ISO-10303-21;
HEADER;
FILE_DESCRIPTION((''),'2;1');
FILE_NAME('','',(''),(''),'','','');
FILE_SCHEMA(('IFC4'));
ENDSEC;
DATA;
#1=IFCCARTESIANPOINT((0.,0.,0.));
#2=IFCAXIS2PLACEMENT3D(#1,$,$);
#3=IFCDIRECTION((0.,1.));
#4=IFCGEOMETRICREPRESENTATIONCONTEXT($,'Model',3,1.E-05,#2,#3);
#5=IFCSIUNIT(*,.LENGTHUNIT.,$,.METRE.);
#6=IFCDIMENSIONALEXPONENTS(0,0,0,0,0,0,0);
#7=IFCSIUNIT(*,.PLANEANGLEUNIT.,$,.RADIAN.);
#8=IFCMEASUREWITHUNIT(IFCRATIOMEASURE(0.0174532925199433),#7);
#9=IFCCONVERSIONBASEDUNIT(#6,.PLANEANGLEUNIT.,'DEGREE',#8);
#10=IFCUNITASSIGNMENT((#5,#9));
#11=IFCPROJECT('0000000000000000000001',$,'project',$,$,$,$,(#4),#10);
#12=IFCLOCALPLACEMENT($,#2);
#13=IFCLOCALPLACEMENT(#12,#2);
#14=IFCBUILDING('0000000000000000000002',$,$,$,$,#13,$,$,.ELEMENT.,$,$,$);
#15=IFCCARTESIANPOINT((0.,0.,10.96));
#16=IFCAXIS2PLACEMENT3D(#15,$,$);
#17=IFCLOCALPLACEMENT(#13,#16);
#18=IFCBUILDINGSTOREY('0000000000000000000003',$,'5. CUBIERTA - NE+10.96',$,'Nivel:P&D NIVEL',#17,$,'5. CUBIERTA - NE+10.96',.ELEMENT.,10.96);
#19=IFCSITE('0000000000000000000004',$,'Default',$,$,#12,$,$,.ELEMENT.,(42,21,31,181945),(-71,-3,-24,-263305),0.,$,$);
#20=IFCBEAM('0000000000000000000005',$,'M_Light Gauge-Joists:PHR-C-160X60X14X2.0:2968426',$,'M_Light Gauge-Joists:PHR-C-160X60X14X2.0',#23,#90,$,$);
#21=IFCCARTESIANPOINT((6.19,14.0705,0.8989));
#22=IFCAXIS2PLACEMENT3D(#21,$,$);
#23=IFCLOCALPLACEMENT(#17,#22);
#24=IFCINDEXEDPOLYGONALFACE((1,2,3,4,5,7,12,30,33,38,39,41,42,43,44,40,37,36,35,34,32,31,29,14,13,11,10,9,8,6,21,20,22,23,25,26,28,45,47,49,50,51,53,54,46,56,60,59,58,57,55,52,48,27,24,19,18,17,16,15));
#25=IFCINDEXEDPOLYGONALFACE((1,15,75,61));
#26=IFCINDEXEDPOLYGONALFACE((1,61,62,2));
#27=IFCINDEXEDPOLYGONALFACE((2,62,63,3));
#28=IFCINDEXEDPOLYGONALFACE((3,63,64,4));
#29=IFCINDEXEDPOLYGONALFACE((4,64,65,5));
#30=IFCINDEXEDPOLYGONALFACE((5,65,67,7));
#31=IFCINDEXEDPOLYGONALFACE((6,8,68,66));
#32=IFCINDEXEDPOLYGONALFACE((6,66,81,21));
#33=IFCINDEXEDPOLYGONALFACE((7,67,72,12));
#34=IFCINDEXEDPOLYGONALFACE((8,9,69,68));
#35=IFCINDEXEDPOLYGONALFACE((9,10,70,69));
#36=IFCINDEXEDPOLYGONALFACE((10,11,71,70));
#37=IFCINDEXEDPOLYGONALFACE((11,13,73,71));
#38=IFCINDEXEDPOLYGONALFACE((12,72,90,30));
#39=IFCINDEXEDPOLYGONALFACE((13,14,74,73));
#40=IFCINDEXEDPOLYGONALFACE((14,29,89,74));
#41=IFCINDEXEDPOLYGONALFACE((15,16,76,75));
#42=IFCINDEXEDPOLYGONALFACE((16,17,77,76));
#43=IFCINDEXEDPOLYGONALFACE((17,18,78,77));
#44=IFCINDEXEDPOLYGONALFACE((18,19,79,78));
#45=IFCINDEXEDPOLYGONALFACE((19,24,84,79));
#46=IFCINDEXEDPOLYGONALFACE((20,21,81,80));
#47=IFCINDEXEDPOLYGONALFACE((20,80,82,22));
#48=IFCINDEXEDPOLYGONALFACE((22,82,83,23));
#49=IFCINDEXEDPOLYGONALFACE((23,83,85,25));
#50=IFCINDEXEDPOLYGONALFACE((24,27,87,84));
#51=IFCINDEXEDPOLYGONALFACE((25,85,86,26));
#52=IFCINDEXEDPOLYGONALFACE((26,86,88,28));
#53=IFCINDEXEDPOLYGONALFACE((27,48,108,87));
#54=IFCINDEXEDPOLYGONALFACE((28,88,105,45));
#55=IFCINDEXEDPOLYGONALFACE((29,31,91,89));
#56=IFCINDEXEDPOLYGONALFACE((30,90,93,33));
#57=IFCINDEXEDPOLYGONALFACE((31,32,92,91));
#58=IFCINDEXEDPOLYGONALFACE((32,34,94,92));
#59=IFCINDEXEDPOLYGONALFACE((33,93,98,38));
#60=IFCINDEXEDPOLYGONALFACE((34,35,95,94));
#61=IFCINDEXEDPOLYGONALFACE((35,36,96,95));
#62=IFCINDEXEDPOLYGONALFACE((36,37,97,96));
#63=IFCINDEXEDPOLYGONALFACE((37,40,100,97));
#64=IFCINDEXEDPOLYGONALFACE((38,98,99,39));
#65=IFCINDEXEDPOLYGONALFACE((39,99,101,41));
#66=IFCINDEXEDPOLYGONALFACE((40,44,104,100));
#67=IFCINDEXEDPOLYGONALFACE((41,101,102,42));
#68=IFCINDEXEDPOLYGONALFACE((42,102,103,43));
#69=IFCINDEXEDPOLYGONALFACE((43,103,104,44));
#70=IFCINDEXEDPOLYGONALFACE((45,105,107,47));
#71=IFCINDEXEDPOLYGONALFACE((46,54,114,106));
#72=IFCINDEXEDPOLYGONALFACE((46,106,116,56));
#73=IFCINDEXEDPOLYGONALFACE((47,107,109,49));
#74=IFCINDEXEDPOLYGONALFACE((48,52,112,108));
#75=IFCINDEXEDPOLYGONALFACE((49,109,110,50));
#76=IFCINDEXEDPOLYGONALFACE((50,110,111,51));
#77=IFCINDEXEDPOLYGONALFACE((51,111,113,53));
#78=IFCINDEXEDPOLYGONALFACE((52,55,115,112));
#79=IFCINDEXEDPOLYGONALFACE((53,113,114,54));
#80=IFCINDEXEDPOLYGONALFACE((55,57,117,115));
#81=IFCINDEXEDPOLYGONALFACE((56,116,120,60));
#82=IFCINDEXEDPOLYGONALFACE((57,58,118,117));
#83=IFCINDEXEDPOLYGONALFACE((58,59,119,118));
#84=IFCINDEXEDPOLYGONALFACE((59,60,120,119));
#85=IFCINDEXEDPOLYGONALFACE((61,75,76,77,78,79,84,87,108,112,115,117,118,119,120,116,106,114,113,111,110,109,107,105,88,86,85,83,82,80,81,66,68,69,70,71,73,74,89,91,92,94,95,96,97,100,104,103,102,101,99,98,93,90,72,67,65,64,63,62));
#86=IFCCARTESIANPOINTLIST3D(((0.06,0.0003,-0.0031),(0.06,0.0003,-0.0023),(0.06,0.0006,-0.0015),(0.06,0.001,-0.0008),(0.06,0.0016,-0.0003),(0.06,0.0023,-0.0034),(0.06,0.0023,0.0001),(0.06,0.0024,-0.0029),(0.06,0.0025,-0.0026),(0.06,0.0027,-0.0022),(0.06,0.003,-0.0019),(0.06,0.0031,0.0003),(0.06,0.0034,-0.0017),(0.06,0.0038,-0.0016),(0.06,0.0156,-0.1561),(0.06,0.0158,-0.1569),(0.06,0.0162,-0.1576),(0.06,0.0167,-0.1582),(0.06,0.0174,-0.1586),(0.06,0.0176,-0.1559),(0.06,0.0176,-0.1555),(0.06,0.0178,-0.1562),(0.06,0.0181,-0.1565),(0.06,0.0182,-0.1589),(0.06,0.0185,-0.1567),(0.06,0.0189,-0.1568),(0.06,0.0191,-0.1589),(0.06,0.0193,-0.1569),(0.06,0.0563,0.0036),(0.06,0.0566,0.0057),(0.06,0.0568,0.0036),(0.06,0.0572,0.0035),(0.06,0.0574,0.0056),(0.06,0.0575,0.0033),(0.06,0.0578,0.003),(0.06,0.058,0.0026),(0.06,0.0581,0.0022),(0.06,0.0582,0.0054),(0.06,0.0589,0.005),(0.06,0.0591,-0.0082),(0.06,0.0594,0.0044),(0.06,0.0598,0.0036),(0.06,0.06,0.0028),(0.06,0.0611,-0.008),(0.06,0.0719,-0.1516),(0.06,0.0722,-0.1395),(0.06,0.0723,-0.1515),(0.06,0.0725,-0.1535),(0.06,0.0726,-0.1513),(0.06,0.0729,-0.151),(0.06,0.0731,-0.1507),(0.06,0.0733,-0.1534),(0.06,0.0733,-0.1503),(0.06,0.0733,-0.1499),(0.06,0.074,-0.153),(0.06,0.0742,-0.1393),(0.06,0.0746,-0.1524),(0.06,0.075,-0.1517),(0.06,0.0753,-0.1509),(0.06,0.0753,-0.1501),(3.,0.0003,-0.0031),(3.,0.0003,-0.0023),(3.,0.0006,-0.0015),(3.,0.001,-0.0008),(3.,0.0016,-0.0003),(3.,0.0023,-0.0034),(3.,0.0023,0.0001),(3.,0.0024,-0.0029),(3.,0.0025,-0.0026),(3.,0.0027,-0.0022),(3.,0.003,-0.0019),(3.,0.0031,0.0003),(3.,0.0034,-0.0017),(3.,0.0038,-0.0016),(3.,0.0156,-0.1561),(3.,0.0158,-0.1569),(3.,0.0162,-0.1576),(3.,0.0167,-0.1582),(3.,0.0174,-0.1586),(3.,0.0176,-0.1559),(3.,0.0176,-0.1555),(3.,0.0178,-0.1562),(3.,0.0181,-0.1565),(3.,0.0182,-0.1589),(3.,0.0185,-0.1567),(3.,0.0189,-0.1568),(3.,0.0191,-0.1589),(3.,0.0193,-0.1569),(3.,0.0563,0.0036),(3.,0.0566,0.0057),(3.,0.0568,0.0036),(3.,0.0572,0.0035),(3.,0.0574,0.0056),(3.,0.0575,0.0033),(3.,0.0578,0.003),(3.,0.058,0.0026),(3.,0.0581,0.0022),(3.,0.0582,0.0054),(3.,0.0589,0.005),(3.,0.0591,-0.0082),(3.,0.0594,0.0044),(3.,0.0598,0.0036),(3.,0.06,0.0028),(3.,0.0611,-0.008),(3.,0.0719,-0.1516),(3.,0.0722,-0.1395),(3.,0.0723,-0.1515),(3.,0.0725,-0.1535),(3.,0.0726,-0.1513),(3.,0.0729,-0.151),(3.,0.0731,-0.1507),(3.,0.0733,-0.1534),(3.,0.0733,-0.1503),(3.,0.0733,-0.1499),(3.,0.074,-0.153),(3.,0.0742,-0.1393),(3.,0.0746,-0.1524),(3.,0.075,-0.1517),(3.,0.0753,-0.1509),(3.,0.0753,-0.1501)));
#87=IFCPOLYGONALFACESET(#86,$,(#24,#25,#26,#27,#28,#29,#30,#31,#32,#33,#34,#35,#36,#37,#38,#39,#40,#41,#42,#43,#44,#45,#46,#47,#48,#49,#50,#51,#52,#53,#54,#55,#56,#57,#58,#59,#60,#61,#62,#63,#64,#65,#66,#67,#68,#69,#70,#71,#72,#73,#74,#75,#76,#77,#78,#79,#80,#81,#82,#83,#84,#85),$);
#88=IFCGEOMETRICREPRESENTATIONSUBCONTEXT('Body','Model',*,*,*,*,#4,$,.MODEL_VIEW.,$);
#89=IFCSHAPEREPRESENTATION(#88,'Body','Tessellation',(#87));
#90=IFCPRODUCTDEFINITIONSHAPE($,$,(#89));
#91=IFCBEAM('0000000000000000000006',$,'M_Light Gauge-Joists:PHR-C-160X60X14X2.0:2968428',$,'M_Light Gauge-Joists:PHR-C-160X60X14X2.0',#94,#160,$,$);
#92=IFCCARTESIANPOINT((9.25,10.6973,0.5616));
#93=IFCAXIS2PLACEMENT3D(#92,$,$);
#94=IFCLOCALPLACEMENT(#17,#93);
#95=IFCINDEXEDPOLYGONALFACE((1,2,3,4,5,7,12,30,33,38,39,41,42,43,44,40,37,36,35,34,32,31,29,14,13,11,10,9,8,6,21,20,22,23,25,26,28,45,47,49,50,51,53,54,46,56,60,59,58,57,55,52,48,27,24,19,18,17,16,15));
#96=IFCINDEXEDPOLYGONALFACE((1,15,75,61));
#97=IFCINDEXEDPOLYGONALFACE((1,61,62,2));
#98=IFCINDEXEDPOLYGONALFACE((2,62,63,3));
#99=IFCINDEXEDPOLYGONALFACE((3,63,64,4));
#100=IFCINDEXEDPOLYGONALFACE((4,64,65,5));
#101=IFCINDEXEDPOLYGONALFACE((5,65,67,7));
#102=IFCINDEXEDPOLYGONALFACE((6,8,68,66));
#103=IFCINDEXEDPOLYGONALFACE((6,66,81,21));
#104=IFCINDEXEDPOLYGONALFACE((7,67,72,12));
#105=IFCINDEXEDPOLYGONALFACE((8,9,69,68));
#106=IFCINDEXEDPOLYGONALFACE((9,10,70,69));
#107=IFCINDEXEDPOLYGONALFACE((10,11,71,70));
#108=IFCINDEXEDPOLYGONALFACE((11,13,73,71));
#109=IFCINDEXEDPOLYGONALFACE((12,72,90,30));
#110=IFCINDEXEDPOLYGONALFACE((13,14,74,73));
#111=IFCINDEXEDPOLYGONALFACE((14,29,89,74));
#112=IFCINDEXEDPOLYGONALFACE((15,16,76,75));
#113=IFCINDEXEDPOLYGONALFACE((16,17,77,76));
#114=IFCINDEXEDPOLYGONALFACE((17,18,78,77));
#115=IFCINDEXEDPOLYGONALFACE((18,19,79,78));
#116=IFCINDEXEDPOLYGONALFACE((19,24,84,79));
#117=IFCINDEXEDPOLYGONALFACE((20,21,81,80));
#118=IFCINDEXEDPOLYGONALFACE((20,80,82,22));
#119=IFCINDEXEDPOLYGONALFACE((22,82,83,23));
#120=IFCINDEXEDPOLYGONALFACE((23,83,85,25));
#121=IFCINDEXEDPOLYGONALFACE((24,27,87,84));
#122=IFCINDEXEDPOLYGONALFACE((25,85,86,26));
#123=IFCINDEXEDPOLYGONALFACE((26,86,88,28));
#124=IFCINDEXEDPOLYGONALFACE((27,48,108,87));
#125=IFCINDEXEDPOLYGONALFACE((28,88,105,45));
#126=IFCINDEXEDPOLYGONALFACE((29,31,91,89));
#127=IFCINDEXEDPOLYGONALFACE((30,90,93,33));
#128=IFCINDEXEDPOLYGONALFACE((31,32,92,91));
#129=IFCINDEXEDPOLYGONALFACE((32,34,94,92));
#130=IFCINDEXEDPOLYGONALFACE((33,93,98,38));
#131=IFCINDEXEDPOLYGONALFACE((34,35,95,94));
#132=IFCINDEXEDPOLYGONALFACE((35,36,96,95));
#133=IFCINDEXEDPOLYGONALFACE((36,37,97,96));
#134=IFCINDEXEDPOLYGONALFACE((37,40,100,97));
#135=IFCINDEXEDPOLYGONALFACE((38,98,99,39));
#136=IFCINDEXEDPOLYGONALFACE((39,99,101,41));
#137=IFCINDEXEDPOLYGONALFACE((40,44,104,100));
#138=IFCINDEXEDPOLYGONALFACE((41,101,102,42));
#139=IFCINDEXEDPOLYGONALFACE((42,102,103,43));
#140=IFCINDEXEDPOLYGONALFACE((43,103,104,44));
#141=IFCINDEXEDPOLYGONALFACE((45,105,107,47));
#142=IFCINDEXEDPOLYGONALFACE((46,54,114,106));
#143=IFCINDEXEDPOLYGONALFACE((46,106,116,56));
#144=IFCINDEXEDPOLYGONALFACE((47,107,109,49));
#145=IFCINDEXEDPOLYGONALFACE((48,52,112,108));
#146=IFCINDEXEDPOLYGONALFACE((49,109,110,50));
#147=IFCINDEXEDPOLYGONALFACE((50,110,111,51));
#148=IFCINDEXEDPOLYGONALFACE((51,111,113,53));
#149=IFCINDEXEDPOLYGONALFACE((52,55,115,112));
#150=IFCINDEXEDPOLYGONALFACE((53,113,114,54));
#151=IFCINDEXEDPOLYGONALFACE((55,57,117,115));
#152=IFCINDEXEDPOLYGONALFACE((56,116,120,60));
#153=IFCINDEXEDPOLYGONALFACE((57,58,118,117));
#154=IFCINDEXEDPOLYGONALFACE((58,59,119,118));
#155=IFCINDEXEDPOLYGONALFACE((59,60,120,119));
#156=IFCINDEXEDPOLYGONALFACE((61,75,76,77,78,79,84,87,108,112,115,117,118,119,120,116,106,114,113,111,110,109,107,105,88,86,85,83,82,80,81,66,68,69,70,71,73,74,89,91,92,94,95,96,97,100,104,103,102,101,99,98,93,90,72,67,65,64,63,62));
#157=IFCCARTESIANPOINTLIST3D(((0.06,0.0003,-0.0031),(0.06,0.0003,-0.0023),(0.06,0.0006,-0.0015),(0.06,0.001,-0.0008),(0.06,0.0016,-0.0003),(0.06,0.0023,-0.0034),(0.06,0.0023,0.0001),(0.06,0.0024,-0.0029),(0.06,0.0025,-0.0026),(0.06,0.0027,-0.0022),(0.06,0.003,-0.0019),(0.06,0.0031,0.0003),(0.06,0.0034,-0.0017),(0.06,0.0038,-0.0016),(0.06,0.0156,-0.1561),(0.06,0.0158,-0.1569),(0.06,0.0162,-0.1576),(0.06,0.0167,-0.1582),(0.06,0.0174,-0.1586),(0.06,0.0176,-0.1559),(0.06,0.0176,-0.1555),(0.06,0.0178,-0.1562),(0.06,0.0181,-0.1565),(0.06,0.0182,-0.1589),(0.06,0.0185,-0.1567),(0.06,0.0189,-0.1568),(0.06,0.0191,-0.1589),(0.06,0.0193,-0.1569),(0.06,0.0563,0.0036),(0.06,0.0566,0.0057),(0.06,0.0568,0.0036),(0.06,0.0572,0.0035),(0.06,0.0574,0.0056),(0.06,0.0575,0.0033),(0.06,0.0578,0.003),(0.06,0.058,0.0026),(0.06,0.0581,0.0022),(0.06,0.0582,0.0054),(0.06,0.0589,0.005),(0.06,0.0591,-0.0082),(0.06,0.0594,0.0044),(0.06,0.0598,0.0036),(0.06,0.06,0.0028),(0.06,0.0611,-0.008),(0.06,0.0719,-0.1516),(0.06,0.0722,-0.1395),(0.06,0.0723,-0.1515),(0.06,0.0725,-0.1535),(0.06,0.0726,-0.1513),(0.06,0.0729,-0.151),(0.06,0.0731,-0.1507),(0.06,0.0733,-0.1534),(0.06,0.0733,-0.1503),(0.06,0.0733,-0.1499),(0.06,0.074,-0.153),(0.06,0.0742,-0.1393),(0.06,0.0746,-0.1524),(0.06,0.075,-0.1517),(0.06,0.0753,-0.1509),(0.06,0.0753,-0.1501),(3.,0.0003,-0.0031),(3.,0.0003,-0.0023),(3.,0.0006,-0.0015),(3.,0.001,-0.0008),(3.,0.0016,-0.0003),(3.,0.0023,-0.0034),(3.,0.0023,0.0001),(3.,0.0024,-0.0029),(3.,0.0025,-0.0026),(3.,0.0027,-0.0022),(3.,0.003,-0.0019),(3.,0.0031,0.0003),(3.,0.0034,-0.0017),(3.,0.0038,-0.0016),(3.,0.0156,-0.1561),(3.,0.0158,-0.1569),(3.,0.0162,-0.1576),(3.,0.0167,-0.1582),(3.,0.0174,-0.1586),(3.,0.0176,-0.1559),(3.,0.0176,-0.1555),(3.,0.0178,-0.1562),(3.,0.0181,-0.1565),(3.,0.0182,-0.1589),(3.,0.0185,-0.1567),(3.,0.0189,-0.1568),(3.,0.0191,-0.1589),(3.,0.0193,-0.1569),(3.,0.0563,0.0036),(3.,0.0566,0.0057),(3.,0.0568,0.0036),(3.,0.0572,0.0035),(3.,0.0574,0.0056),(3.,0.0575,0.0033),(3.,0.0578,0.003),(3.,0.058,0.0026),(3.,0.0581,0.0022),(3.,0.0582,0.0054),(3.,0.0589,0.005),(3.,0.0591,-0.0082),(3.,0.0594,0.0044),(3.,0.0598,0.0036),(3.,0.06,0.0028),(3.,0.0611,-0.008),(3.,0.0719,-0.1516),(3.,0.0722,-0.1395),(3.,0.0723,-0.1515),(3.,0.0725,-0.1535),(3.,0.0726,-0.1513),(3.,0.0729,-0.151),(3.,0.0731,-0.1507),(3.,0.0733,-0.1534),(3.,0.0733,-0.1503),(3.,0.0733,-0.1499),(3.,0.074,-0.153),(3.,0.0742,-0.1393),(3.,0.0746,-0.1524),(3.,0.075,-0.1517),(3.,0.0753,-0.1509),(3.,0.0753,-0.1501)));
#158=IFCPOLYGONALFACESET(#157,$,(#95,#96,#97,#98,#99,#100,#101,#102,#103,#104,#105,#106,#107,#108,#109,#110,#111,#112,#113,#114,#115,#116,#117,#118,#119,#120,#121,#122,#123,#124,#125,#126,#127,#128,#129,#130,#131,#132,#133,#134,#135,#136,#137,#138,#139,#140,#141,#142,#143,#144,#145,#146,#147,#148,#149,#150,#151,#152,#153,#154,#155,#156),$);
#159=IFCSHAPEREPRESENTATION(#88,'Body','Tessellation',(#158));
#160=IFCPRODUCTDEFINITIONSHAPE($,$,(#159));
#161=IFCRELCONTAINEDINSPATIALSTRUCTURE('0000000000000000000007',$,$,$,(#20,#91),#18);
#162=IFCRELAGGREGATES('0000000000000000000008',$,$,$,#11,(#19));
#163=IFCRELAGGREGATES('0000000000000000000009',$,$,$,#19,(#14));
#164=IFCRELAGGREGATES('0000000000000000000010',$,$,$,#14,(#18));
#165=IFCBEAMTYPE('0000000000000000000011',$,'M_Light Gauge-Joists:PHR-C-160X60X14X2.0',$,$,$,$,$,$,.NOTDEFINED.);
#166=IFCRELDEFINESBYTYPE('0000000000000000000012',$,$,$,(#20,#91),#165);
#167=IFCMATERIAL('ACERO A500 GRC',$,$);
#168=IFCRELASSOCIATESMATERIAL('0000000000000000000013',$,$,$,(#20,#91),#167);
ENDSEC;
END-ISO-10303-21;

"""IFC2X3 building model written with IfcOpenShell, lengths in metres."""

from ifc_helpers import new_model, entity, si_unit, converted_unit, direction, frame, frame_2d, origin, place, context, subcontext, project, spatial, polyline, circle_curve, parameter, trimmed, segment, composite_curve, outline, extrude, material, type_object, element, save


model = new_model("IFC2X3")

# Units and contexts
model_context = context("Model", 3, precision=1e-05, world=origin(), true_north=direction((0.0, 1.0)))
body_context = subcontext(model_context, "Body", "Model", "MODEL_VIEW")
ifc_project = project(units=[si_unit("LENGTHUNIT", "METRE"), converted_unit("PLANEANGLEUNIT", "DEGREE", entity("IfcRatioMeasure", 0.0174532925199433), si_unit("PLANEANGLEUNIT", "RADIAN"), dimensions=[0, 0, 0, 0, 0, 0, 0])], contexts=[model_context])

# Site, building, storey
site_placement = place(None, origin())
site = spatial("IfcSite", under=ifc_project, at=site_placement, Name="Default", CompositionType="ELEMENT", RefLatitude=(42, 21, 31, 181945), RefLongitude=(-71, -3, -24, -263305), RefElevation=0.0)
building_placement = place(site_placement, origin())
building = spatial("IfcBuilding", under=site, at=building_placement, CompositionType="ELEMENT")
storey_placement = place(building_placement, frame((0.0, 0.0, 10.96)))
storey = spatial("IfcBuildingStorey", under=building, at=storey_placement, Name="5. CUBIERTA - NE+10.96", ObjectType="Nivel:P&D NIVEL", LongName="5. CUBIERTA - NE+10.96", CompositionType="ELEMENT", Elevation=10.96)

# Beams
ifc_material_1 = material(Name="ACERO A500 GRC")
beam_type_1 = type_object("IfcBeamType", Name="M_Light Gauge-Joists:PHR-C-160X60X14X2.0", PredefinedType="NOTDEFINED")
beam_1_placement = place(storey_placement, frame((6.19, 14.0705, 0.8989)))
element("IfcBeam", 1, at=beam_1_placement, inside=storey, type_object=beam_type_1, material=ifc_material_1, Name="M_Light Gauge-Joists:PHR-C-160X60X14X2.0:2968426", ObjectType="M_Light Gauge-Joists:PHR-C-160X60X14X2.0", context=body_context, shape_type="SweptSolid", body=[
    extrude(outline(composite_curve([segment(trimmed(circle_curve(frame_2d((-0.0764, -0.0322), x_axis=(-1.0, 0.0)), 0.0016), [parameter(0.0)], [parameter(90.0)], True, "PARAMETER"), False, "CONTINUOUS"), segment(polyline([(-0.078, -0.0322), (-0.078, 0.0206)]), True, "CONTINUOUS"), segment(trimmed(circle_curve(frame_2d((-0.0764, 0.0206), x_axis=(0.0, 1.0)), 0.0016), [parameter(0.0)], [parameter(90.0)], True, "PARAMETER"), False, "CONTINUOUS"), segment(polyline([(-0.0764, 0.0222), (-0.066, 0.0222)]), True, "CONTINUOUS"), segment(polyline([(-0.066, 0.0222), (-0.066, 0.0242)]), True, "CONTINUOUS"), segment(polyline([(-0.066, 0.0242), (-0.0768, 0.0242)]), True, "CONTINUOUS"), segment(trimmed(circle_curve(frame_2d((-0.0768, 0.021), x_axis=(-1.0, 0.0)), 0.0032), [parameter(270.0)], [parameter(0.0)], True, "PARAMETER"), True, "CONTINUOUS"), segment(polyline([(-0.08, 0.021), (-0.08, -0.0326)]), True, "CONTINUOUS"), segment(trimmed(circle_curve(frame_2d((-0.0768, -0.0326), x_axis=(0.0, -1.0)), 0.0032), [parameter(270.0)], [parameter(0.0)], True, "PARAMETER"), True, "CONTINUOUS"), segment(polyline([(-0.0768, -0.0358), (0.0768, -0.0358)]), True, "CONTINUOUS"), segment(trimmed(circle_curve(frame_2d((0.0768, -0.0326), x_axis=(1.0, 0.0)), 0.0032), [parameter(270.0)], [parameter(0.0)], True, "PARAMETER"), True, "CONTINUOUS"), segment(polyline([(0.08, -0.0326), (0.08, 0.021)]), True, "CONTINUOUS"), segment(trimmed(circle_curve(frame_2d((0.0768, 0.021), x_axis=(0.0, 1.0)), 0.0032), [parameter(270.0)], [parameter(0.0)], True, "PARAMETER"), True, "CONTINUOUS"), segment(polyline([(0.0768, 0.0242), (0.066, 0.0242)]), True, "CONTINUOUS"), segment(polyline([(0.066, 0.0242), (0.066, 0.0222)]), True, "CONTINUOUS"), segment(polyline([(0.066, 0.0222), (0.0764, 0.0222)]), True, "CONTINUOUS"), segment(trimmed(circle_curve(frame_2d((0.0764, 0.0206), x_axis=(1.0, 0.0)), 0.0016), [parameter(0.0)], [parameter(90.0)], True, "PARAMETER"), False, "CONTINUOUS"), segment(polyline([(0.078, 0.0206), (0.078, -0.0322)]), True, "CONTINUOUS"), segment(trimmed(circle_curve(frame_2d((0.0764, -0.0322), x_axis=(0.0, -1.0)), 0.0016), [parameter(0.0)], [parameter(90.0)], True, "PARAMETER"), False, "CONTINUOUS"), segment(polyline([(0.0764, -0.0338), (-0.0764, -0.0338)]), True, "CONTINUOUS")], self_intersect=False)), frame((0.06, 0.0436, -0.076), z_axis=(-1.0, 0.0, 0.0), x_axis=(0.0, -0.099504, 0.995037)), (0.0, 0.0, -1.0), 2.94),
])
beam_2_placement = place(storey_placement, frame((9.25, 10.6973, 0.5616)))
element("IfcBeam", 2, at=beam_2_placement, inside=storey, type_object=beam_type_1, material=ifc_material_1, Name="M_Light Gauge-Joists:PHR-C-160X60X14X2.0:2968428", ObjectType="M_Light Gauge-Joists:PHR-C-160X60X14X2.0", context=body_context, shape_type="SweptSolid", body=[
    extrude(outline(composite_curve([segment(trimmed(circle_curve(frame_2d((-0.0764, -0.0322), x_axis=(-1.0, 0.0)), 0.0016), [parameter(0.0)], [parameter(90.0)], True, "PARAMETER"), False, "CONTINUOUS"), segment(polyline([(-0.078, -0.0322), (-0.078, 0.0206)]), True, "CONTINUOUS"), segment(trimmed(circle_curve(frame_2d((-0.0764, 0.0206), x_axis=(0.0, 1.0)), 0.0016), [parameter(0.0)], [parameter(90.0)], True, "PARAMETER"), False, "CONTINUOUS"), segment(polyline([(-0.0764, 0.0222), (-0.066, 0.0222)]), True, "CONTINUOUS"), segment(polyline([(-0.066, 0.0222), (-0.066, 0.0242)]), True, "CONTINUOUS"), segment(polyline([(-0.066, 0.0242), (-0.0768, 0.0242)]), True, "CONTINUOUS"), segment(trimmed(circle_curve(frame_2d((-0.0768, 0.021), x_axis=(-1.0, 0.0)), 0.0032), [parameter(270.0)], [parameter(0.0)], True, "PARAMETER"), True, "CONTINUOUS"), segment(polyline([(-0.08, 0.021), (-0.08, -0.0326)]), True, "CONTINUOUS"), segment(trimmed(circle_curve(frame_2d((-0.0768, -0.0326), x_axis=(0.0, -1.0)), 0.0032), [parameter(270.0)], [parameter(0.0)], True, "PARAMETER"), True, "CONTINUOUS"), segment(polyline([(-0.0768, -0.0358), (0.0768, -0.0358)]), True, "CONTINUOUS"), segment(trimmed(circle_curve(frame_2d((0.0768, -0.0326), x_axis=(1.0, 0.0)), 0.0032), [parameter(270.0)], [parameter(0.0)], True, "PARAMETER"), True, "CONTINUOUS"), segment(polyline([(0.08, -0.0326), (0.08, 0.021)]), True, "CONTINUOUS"), segment(trimmed(circle_curve(frame_2d((0.0768, 0.021), x_axis=(0.0, 1.0)), 0.0032), [parameter(270.0)], [parameter(0.0)], True, "PARAMETER"), True, "CONTINUOUS"), segment(polyline([(0.0768, 0.0242), (0.066, 0.0242)]), True, "CONTINUOUS"), segment(polyline([(0.066, 0.0242), (0.066, 0.0222)]), True, "CONTINUOUS"), segment(polyline([(0.066, 0.0222), (0.0764, 0.0222)]), True, "CONTINUOUS"), segment(trimmed(circle_curve(frame_2d((0.0764, 0.0206), x_axis=(1.0, 0.0)), 0.0016), [parameter(0.0)], [parameter(90.0)], True, "PARAMETER"), False, "CONTINUOUS"), segment(polyline([(0.078, 0.0206), (0.078, -0.0322)]), True, "CONTINUOUS"), segment(trimmed(circle_curve(frame_2d((0.0764, -0.0322), x_axis=(0.0, -1.0)), 0.0016), [parameter(0.0)], [parameter(90.0)], True, "PARAMETER"), False, "CONTINUOUS"), segment(polyline([(0.0764, -0.0338), (-0.0764, -0.0338)]), True, "CONTINUOUS")], self_intersect=False)), frame((0.06, 0.0436, -0.076), z_axis=(-1.0, 0.0, 0.0), x_axis=(0.0, -0.099504, 0.995037)), (0.0, 0.0, -1.0), 2.94),
])

save(model, "model.ifc")
